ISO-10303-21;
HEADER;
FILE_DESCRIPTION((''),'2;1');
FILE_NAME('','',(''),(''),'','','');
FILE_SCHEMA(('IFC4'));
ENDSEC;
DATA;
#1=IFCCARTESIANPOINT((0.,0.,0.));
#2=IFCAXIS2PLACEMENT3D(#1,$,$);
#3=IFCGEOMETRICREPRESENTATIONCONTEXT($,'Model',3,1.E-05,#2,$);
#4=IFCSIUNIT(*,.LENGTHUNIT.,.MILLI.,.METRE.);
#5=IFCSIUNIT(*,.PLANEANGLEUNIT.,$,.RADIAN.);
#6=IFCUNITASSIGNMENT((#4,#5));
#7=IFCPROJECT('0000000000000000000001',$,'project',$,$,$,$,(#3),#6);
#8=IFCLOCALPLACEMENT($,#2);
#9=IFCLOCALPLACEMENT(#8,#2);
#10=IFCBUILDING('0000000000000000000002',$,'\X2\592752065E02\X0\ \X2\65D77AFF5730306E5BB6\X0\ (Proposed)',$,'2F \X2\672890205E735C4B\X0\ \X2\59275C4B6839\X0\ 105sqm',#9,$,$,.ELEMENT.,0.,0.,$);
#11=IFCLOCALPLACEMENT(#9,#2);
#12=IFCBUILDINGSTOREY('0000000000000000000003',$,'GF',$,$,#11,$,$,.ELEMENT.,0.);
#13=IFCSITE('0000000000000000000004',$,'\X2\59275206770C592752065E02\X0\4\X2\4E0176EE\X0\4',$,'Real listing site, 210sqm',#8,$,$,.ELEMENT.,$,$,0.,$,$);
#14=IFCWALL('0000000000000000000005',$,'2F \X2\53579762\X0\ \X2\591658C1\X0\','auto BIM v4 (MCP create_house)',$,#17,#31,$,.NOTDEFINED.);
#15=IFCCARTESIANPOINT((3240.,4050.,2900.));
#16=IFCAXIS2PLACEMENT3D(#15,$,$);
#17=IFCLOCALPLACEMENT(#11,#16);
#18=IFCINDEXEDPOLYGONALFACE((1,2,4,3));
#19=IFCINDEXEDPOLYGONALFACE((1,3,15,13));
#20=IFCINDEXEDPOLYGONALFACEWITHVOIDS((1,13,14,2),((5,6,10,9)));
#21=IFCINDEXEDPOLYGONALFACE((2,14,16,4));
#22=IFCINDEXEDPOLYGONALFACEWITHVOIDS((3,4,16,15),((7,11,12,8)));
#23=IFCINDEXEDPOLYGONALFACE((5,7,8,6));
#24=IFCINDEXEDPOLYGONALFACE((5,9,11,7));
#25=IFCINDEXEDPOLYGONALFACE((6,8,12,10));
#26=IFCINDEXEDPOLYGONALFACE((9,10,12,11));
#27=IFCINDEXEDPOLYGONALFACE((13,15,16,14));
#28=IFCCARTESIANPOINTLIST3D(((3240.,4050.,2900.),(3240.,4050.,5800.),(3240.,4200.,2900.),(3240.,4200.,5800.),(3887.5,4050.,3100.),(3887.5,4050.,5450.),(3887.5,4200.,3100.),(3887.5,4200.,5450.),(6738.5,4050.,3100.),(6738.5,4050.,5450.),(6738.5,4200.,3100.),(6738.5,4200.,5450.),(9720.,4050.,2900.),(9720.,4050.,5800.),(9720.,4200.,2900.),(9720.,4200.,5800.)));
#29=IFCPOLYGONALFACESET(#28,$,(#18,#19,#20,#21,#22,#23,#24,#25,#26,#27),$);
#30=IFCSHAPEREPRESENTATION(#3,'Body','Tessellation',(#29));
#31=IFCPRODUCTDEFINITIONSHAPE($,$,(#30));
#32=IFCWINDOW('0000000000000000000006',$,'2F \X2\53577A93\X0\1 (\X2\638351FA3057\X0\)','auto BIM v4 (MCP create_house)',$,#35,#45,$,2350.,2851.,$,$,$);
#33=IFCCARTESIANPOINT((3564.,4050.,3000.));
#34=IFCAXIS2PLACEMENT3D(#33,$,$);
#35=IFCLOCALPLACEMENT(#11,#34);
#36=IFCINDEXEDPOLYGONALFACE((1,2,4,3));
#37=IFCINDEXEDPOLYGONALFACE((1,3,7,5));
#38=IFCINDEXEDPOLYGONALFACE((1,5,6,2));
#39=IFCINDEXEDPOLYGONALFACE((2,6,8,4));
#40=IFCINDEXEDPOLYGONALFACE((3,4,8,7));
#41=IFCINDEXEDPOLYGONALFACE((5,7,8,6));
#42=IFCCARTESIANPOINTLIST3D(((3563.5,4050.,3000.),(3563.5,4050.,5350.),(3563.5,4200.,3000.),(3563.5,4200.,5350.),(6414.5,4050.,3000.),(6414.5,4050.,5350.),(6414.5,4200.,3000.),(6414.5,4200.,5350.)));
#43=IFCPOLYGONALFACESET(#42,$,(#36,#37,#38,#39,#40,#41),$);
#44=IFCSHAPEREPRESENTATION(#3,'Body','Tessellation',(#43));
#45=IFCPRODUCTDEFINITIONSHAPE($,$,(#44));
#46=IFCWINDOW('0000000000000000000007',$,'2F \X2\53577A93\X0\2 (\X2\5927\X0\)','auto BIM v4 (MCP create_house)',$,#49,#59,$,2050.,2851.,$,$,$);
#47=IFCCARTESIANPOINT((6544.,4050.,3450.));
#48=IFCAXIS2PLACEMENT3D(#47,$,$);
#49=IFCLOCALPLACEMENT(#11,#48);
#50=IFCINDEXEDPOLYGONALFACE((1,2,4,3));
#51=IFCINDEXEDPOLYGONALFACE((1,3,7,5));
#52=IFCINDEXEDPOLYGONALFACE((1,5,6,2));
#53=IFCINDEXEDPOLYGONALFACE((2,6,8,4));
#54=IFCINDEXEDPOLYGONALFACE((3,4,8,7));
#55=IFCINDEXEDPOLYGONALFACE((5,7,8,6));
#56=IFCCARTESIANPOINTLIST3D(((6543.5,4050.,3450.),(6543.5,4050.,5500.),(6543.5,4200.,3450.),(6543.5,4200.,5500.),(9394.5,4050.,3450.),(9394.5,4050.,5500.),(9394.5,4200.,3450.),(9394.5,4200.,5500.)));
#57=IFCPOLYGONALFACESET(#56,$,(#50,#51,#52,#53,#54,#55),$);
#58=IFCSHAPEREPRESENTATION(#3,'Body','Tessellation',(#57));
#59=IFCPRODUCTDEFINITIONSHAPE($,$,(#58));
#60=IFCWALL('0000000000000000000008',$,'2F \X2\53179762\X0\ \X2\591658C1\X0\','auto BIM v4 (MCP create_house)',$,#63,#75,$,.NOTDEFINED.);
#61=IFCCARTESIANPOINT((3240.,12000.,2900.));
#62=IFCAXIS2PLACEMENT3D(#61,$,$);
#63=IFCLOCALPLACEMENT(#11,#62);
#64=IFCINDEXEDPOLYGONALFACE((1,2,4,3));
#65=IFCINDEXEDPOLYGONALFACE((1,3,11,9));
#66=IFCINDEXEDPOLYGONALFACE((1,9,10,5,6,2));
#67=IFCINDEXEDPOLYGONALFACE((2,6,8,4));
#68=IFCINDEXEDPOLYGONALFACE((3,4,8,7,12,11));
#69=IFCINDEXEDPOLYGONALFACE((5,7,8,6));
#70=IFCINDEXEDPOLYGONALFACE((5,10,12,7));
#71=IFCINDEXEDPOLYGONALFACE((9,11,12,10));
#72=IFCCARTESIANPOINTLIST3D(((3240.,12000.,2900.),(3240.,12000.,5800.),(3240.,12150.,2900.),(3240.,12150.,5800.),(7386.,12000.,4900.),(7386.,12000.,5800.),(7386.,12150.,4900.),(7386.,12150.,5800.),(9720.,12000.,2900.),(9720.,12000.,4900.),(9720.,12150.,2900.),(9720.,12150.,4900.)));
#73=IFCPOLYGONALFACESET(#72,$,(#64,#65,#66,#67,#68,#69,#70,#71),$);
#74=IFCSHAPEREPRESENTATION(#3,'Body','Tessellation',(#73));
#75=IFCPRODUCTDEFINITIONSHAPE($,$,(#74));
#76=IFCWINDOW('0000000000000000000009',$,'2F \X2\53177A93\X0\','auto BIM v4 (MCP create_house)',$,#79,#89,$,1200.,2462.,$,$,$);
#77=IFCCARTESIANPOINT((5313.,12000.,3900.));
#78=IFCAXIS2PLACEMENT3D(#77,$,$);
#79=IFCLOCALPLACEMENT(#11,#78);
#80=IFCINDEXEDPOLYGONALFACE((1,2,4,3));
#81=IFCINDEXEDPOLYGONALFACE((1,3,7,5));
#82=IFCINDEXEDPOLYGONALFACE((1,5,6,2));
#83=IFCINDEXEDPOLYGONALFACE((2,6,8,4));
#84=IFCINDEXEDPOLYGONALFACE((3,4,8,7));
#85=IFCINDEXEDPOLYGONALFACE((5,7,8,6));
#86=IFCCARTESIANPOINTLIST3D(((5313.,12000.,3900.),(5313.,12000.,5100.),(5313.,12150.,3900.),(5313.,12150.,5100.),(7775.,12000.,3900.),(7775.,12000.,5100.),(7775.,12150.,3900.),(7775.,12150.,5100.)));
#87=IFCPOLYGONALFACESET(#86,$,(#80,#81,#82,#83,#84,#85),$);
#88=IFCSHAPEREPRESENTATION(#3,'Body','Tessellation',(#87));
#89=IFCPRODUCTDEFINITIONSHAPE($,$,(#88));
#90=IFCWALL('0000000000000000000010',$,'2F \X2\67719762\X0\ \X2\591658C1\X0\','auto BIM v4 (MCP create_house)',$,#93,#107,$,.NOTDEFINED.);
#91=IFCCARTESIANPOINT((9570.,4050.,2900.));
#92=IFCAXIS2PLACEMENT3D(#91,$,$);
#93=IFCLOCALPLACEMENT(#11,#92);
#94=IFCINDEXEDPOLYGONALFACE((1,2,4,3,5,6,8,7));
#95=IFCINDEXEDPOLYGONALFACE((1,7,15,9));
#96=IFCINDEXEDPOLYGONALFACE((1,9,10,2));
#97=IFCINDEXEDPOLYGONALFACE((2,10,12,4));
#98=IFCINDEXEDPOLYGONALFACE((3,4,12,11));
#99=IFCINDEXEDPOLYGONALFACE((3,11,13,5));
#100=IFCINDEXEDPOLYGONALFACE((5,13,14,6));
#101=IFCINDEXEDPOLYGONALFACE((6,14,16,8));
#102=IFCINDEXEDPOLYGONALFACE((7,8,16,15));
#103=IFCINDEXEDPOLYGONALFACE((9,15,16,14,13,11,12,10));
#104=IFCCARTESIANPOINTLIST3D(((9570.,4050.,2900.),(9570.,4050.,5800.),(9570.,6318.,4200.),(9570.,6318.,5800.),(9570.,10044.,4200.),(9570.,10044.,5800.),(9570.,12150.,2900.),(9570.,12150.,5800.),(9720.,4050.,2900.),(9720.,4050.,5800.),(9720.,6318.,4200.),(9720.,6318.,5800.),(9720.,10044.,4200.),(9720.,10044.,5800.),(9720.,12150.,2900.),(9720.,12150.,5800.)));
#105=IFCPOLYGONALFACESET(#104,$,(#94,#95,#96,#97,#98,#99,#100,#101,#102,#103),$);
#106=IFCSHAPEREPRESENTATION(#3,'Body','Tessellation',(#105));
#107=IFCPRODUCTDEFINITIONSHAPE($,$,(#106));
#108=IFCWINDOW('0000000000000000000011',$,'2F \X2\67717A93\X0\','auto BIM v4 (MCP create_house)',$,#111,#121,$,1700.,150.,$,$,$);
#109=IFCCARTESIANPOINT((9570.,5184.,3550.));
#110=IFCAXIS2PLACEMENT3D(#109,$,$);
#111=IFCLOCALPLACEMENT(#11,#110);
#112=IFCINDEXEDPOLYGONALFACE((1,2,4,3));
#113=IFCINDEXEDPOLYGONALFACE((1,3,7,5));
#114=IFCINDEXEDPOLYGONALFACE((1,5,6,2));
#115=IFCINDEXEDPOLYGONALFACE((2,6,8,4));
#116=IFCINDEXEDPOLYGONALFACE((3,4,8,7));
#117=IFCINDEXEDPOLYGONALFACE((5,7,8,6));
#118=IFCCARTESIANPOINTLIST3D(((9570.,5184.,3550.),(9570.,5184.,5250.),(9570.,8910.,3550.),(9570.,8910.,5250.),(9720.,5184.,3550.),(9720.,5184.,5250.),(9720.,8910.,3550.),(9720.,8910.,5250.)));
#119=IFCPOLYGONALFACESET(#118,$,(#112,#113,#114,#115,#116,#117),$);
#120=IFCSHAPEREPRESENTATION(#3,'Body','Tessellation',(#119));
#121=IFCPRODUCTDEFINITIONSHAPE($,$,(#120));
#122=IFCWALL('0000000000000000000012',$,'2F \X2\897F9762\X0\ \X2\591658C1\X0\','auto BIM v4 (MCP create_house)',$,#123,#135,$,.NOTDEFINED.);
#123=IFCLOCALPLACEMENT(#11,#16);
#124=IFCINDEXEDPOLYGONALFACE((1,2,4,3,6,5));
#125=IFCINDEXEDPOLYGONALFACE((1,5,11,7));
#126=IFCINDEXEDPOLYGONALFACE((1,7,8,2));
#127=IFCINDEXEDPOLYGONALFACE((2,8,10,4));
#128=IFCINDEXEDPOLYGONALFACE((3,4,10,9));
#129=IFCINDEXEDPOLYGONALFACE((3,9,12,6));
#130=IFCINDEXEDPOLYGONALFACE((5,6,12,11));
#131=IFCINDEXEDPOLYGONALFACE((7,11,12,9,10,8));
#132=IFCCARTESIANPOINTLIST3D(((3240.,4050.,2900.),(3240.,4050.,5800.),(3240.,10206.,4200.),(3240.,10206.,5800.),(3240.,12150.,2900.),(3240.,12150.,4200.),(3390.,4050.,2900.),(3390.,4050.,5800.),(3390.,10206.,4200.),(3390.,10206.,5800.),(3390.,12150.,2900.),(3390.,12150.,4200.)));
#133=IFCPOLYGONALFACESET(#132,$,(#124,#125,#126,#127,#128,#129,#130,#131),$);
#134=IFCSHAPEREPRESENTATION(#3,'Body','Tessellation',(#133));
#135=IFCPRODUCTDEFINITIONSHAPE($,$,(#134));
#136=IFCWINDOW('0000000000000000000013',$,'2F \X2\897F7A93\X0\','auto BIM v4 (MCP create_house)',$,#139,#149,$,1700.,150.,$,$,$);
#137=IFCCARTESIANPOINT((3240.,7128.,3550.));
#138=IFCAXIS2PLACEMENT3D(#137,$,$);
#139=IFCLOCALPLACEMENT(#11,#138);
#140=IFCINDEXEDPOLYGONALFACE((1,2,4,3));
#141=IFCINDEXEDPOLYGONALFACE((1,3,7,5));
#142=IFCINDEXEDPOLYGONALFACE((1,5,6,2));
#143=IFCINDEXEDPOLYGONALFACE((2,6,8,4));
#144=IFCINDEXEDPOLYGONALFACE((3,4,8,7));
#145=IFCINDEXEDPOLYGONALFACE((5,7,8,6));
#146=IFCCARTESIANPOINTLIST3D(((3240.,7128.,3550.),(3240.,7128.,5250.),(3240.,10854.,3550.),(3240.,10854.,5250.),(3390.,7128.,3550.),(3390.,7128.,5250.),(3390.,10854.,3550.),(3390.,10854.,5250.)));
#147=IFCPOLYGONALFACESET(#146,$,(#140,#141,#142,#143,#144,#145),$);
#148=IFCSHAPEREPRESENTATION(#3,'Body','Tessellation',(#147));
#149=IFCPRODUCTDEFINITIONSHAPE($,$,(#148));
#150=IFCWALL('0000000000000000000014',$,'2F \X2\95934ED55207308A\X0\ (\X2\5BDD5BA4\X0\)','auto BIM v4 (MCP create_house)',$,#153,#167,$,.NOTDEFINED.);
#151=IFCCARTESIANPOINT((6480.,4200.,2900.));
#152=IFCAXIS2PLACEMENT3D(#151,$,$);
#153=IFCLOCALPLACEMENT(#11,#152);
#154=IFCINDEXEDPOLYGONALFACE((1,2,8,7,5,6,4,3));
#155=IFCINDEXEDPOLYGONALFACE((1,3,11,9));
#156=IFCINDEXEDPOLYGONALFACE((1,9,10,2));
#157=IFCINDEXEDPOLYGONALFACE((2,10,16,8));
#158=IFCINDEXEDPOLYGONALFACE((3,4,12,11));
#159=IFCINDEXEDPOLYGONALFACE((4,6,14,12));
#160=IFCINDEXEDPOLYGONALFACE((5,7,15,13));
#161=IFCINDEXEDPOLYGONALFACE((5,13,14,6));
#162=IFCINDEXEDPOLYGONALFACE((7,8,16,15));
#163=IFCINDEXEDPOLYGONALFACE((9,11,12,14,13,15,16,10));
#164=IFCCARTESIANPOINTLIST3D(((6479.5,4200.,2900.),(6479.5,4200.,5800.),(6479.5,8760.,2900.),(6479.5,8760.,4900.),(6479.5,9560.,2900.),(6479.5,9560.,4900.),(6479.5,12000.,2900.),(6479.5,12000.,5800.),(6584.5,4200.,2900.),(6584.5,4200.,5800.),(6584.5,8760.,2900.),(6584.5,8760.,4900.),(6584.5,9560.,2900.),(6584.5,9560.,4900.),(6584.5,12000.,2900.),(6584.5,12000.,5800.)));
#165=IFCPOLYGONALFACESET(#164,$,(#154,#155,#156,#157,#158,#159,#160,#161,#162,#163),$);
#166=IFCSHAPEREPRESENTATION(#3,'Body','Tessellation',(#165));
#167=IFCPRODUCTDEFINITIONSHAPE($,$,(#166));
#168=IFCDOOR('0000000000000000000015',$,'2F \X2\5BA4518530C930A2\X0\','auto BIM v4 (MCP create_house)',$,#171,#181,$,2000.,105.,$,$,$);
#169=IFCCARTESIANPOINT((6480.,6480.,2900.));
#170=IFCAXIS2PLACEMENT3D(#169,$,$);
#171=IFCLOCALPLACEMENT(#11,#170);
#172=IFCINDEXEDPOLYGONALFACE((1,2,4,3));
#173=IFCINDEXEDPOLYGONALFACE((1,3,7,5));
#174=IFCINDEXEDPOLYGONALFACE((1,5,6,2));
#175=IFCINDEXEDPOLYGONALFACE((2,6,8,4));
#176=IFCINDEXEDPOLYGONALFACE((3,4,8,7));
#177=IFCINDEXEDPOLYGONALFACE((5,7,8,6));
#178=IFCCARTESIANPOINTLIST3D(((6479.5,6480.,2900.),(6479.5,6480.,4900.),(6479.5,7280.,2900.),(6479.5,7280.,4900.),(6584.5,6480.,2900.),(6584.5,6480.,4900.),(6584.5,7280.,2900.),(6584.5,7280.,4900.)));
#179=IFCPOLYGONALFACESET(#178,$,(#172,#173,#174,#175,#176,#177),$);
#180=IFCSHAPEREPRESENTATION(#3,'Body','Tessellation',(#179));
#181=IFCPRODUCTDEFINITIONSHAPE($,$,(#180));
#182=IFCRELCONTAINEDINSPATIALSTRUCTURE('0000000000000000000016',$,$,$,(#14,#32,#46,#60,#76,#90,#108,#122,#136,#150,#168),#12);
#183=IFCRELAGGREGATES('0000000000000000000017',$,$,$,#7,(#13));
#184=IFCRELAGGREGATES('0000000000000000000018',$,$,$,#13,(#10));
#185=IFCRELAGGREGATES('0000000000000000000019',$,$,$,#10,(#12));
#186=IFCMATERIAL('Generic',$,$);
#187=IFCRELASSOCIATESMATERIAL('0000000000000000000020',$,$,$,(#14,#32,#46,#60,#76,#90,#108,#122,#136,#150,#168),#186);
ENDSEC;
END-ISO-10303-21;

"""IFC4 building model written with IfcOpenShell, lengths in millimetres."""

from ifc_helpers import new_model, si_unit, frame, frame_2d, origin, place, context, project, spatial, rectangle, extrude, material, element, fill, save


model = new_model("IFC4")

# Units and contexts
model_context = context("Model", 3, precision=1e-05, world=origin())
ifc_project = project(units=[si_unit("LENGTHUNIT", "METRE", prefix="MILLI"), si_unit("PLANEANGLEUNIT", "RADIAN")], contexts=[model_context])

# Site, building, storey
site_placement = place(None, origin())
site = spatial("IfcSite", under=ifc_project, at=site_placement, Name="大分県大分市4丁目4", ObjectType="Real listing site, 210sqm", CompositionType="ELEMENT", RefElevation=0.0)
building_placement = place(site_placement, origin())
building = spatial("IfcBuilding", under=site, at=building_placement, Name="大分市 旗竿地の家 (Proposed)", ObjectType="2F 木造平屋 大屋根 105sqm", CompositionType="ELEMENT", ElevationOfRefHeight=0.0, ElevationOfTerrain=0.0)
storey_placement = place(building_placement, origin())
storey = spatial("IfcBuildingStorey", under=building, at=storey_placement, Name="GF", CompositionType="ELEMENT", Elevation=0.0)

# Shared definitions
ifc_material = material(Name="Generic")

# Wall, openings, windows
wall_1_placement = place(storey_placement, frame((3240.0, 4050.0, 2900.0)))
wall_1 = element("IfcWall", 1, at=wall_1_placement, inside=storey, material=ifc_material, Name="2F 南面 外壁", Description="auto BIM v4 (MCP create_house)", PredefinedType="NOTDEFINED", context=model_context, shape_type="SweptSolid", body=[
    extrude(rectangle(XDim=6480.0, YDim=150.0, at=frame_2d((3240.0, 75.0))), frame((3240.0, 4050.0, 2900.0)), (0.0, 0.0, 1.0), 2900.0),
])
opening_1_placement = place(storey_placement, frame((3564.0, 4050.0, 3000.0)))
opening_1 = element("IfcOpeningElement", 2, at=opening_1_placement, cuts=wall_1, PredefinedType="NOTDEFINED", context=model_context, shape_type="SweptSolid", body=[
    extrude(rectangle(XDim=2851.0, YDim=150.0, at=frame_2d((1425.0, 75.0))), frame((3564.0, 4050.0, 3000.0)), (0.0, 0.0, 1.0), 2350.0),
])
opening_2_placement = place(storey_placement, frame((6544.0, 4050.0, 3450.0)))
opening_2 = element("IfcOpeningElement", 3, at=opening_2_placement, cuts=wall_1, PredefinedType="NOTDEFINED", context=model_context, shape_type="SweptSolid", body=[
    extrude(rectangle(XDim=2851.0, YDim=150.0, at=frame_2d((1425.0, 75.0))), frame((6544.0, 4050.0, 3450.0)), (0.0, 0.0, 1.0), 2050.0),
])
window_1_placement = place(storey_placement, frame((3564.0, 4050.0, 3000.0)))
window_1 = element("IfcWindow", 4, at=window_1_placement, inside=storey, material=ifc_material, Name="2F 南窓1 (掃出し)", Description="auto BIM v4 (MCP create_house)", OverallHeight=2350.0, OverallWidth=2851.0, context=model_context, shape_type="SweptSolid", body=[
    extrude(rectangle(XDim=2851.0, YDim=150.0, at=frame_2d((1425.0, 75.0))), frame((3564.0, 4050.0, 3000.0)), (0.0, 0.0, 1.0), 2350.0),
])
fill(opening_1, window_1)
window_2_placement = place(storey_placement, frame((6544.0, 4050.0, 3450.0)))
window_2 = element("IfcWindow", 5, at=window_2_placement, inside=storey, material=ifc_material, Name="2F 南窓2 (大)", Description="auto BIM v4 (MCP create_house)", OverallHeight=2050.0, OverallWidth=2851.0, context=model_context, shape_type="SweptSolid", body=[
    extrude(rectangle(XDim=2851.0, YDim=150.0, at=frame_2d((1425.0, 75.0))), frame((6544.0, 4050.0, 3450.0)), (0.0, 0.0, 1.0), 2050.0),
])
fill(opening_2, window_2)

# Walls, openings, windows
wall_2_placement = place(storey_placement, frame((3240.0, 12000.0, 2900.0)))
wall_2 = element("IfcWall", 6, at=wall_2_placement, inside=storey, material=ifc_material, Name="2F 北面 外壁", Description="auto BIM v4 (MCP create_house)", PredefinedType="NOTDEFINED", context=model_context, shape_type="SweptSolid", body=[
    extrude(rectangle(XDim=6480.0, YDim=150.0, at=frame_2d((3240.0, 75.0))), frame((3240.0, 12000.0, 2900.0)), (0.0, 0.0, 1.0), 2900.0),
])
opening_3_placement = place(storey_placement, frame((5313.0, 12000.0, 3900.0)))
opening_3 = element("IfcOpeningElement", 7, at=opening_3_placement, cuts=wall_2, PredefinedType="NOTDEFINED", context=model_context, shape_type="SweptSolid", body=[
    extrude(rectangle(XDim=2462.0, YDim=150.0, at=frame_2d((1231.0, 75.0))), frame((5313.0, 12000.0, 3900.0)), (0.0, 0.0, 1.0), 1200.0),
])
window_3_placement = place(storey_placement, frame((5313.0, 12000.0, 3900.0)))
window_3 = element("IfcWindow", 8, at=window_3_placement, inside=storey, material=ifc_material, Name="2F 北窓", Description="auto BIM v4 (MCP create_house)", OverallHeight=1200.0, OverallWidth=2462.0, context=model_context, shape_type="SweptSolid", body=[
    extrude(rectangle(XDim=2462.0, YDim=150.0, at=frame_2d((1231.0, 75.0))), frame((5313.0, 12000.0, 3900.0)), (0.0, 0.0, 1.0), 1200.0),
])
fill(opening_3, window_3)
wall_3_placement = place(storey_placement, frame((9570.0, 4050.0, 2900.0)))
wall_3 = element("IfcWall", 9, at=wall_3_placement, inside=storey, material=ifc_material, Name="2F 東面 外壁", Description="auto BIM v4 (MCP create_house)", PredefinedType="NOTDEFINED", context=model_context, shape_type="SweptSolid", body=[
    extrude(rectangle(XDim=150.0, YDim=8100.0, at=frame_2d((75.0, 4050.0))), frame((9570.0, 4050.0, 2900.0)), (0.0, 0.0, 1.0), 2900.0),
])
opening_4_placement = place(storey_placement, frame((9570.0, 5184.0, 3550.0)))
opening_4 = element("IfcOpeningElement", 10, at=opening_4_placement, cuts=wall_3, PredefinedType="NOTDEFINED", context=model_context, shape_type="SweptSolid", body=[
    extrude(rectangle(XDim=150.0, YDim=3726.0, at=frame_2d((75.0, 1863.0))), frame((9570.0, 5184.0, 3550.0)), (0.0, 0.0, 1.0), 1700.0),
])
window_4_placement = place(storey_placement, frame((9570.0, 5184.0, 3550.0)))
window_4 = element("IfcWindow", 11, at=window_4_placement, inside=storey, material=ifc_material, Name="2F 東窓", Description="auto BIM v4 (MCP create_house)", OverallHeight=1700.0, OverallWidth=150.0, context=model_context, shape_type="SweptSolid", body=[
    extrude(rectangle(XDim=150.0, YDim=3726.0, at=frame_2d((75.0, 1863.0))), frame((9570.0, 5184.0, 3550.0)), (0.0, 0.0, 1.0), 1700.0),
])
fill(opening_4, window_4)
wall_4_placement = place(storey_placement, frame((3240.0, 4050.0, 2900.0)))
wall_4 = element("IfcWall", 12, at=wall_4_placement, inside=storey, material=ifc_material, Name="2F 西面 外壁", Description="auto BIM v4 (MCP create_house)", PredefinedType="NOTDEFINED", context=model_context, shape_type="SweptSolid", body=[
    extrude(rectangle(XDim=150.0, YDim=8100.0, at=frame_2d((75.0, 4050.0))), frame((3240.0, 4050.0, 2900.0)), (0.0, 0.0, 1.0), 2900.0),
])
opening_5_placement = place(storey_placement, frame((3240.0, 7128.0, 3550.0)))
opening_5 = element("IfcOpeningElement", 13, at=opening_5_placement, cuts=wall_4, PredefinedType="NOTDEFINED", context=model_context, shape_type="SweptSolid", body=[
    extrude(rectangle(XDim=150.0, YDim=3726.0, at=frame_2d((75.0, 1863.0))), frame((3240.0, 7128.0, 3550.0)), (0.0, 0.0, 1.0), 1700.0),
])
window_5_placement = place(storey_placement, frame((3240.0, 7128.0, 3550.0)))
window_5 = element("IfcWindow", 14, at=window_5_placement, inside=storey, material=ifc_material, Name="2F 西窓", Description="auto BIM v4 (MCP create_house)", OverallHeight=1700.0, OverallWidth=150.0, context=model_context, shape_type="SweptSolid", body=[
    extrude(rectangle(XDim=150.0, YDim=3726.0, at=frame_2d((75.0, 1863.0))), frame((3240.0, 7128.0, 3550.0)), (0.0, 0.0, 1.0), 1700.0),
])
fill(opening_5, window_5)

# Wall, opening, door
wall_5_placement = place(storey_placement, frame((6480.0, 4200.0, 2900.0)))
wall_5 = element("IfcWall", 15, at=wall_5_placement, inside=storey, material=ifc_material, Name="2F 間仕切り (寝室)", Description="auto BIM v4 (MCP create_house)", PredefinedType="NOTDEFINED", context=model_context, shape_type="SweptSolid", body=[
    extrude(rectangle(XDim=105.0, YDim=7800.0, at=frame_2d((52.0, 3900.0))), frame((6480.0, 4200.0, 2900.0)), (0.0, 0.0, 1.0), 2900.0),
])
opening_6_placement = place(storey_placement, frame((6480.0, 6480.0, 2900.0)))
opening_6 = element("IfcOpeningElement", 16, at=opening_6_placement, cuts=wall_5, PredefinedType="NOTDEFINED", context=model_context, shape_type="SweptSolid", body=[
    extrude(rectangle(XDim=105.0, YDim=800.0, at=frame_2d((52.0, 400.0))), frame((6480.0, 6480.0, 2900.0)), (0.0, 0.0, 1.0), 2000.0),
])
door_1_placement = place(storey_placement, frame((6480.0, 6480.0, 2900.0)))
door_1 = element("IfcDoor", 17, at=door_1_placement, inside=storey, material=ifc_material, Name="2F 室内ドア", Description="auto BIM v4 (MCP create_house)", OverallHeight=2000.0, OverallWidth=105.0, context=model_context, shape_type="SweptSolid", body=[
    extrude(rectangle(XDim=105.0, YDim=800.0, at=frame_2d((52.0, 400.0))), frame((6480.0, 6480.0, 2900.0)), (0.0, 0.0, 1.0), 2000.0),
])
fill(opening_6, door_1)

save(model, "model.ifc")
